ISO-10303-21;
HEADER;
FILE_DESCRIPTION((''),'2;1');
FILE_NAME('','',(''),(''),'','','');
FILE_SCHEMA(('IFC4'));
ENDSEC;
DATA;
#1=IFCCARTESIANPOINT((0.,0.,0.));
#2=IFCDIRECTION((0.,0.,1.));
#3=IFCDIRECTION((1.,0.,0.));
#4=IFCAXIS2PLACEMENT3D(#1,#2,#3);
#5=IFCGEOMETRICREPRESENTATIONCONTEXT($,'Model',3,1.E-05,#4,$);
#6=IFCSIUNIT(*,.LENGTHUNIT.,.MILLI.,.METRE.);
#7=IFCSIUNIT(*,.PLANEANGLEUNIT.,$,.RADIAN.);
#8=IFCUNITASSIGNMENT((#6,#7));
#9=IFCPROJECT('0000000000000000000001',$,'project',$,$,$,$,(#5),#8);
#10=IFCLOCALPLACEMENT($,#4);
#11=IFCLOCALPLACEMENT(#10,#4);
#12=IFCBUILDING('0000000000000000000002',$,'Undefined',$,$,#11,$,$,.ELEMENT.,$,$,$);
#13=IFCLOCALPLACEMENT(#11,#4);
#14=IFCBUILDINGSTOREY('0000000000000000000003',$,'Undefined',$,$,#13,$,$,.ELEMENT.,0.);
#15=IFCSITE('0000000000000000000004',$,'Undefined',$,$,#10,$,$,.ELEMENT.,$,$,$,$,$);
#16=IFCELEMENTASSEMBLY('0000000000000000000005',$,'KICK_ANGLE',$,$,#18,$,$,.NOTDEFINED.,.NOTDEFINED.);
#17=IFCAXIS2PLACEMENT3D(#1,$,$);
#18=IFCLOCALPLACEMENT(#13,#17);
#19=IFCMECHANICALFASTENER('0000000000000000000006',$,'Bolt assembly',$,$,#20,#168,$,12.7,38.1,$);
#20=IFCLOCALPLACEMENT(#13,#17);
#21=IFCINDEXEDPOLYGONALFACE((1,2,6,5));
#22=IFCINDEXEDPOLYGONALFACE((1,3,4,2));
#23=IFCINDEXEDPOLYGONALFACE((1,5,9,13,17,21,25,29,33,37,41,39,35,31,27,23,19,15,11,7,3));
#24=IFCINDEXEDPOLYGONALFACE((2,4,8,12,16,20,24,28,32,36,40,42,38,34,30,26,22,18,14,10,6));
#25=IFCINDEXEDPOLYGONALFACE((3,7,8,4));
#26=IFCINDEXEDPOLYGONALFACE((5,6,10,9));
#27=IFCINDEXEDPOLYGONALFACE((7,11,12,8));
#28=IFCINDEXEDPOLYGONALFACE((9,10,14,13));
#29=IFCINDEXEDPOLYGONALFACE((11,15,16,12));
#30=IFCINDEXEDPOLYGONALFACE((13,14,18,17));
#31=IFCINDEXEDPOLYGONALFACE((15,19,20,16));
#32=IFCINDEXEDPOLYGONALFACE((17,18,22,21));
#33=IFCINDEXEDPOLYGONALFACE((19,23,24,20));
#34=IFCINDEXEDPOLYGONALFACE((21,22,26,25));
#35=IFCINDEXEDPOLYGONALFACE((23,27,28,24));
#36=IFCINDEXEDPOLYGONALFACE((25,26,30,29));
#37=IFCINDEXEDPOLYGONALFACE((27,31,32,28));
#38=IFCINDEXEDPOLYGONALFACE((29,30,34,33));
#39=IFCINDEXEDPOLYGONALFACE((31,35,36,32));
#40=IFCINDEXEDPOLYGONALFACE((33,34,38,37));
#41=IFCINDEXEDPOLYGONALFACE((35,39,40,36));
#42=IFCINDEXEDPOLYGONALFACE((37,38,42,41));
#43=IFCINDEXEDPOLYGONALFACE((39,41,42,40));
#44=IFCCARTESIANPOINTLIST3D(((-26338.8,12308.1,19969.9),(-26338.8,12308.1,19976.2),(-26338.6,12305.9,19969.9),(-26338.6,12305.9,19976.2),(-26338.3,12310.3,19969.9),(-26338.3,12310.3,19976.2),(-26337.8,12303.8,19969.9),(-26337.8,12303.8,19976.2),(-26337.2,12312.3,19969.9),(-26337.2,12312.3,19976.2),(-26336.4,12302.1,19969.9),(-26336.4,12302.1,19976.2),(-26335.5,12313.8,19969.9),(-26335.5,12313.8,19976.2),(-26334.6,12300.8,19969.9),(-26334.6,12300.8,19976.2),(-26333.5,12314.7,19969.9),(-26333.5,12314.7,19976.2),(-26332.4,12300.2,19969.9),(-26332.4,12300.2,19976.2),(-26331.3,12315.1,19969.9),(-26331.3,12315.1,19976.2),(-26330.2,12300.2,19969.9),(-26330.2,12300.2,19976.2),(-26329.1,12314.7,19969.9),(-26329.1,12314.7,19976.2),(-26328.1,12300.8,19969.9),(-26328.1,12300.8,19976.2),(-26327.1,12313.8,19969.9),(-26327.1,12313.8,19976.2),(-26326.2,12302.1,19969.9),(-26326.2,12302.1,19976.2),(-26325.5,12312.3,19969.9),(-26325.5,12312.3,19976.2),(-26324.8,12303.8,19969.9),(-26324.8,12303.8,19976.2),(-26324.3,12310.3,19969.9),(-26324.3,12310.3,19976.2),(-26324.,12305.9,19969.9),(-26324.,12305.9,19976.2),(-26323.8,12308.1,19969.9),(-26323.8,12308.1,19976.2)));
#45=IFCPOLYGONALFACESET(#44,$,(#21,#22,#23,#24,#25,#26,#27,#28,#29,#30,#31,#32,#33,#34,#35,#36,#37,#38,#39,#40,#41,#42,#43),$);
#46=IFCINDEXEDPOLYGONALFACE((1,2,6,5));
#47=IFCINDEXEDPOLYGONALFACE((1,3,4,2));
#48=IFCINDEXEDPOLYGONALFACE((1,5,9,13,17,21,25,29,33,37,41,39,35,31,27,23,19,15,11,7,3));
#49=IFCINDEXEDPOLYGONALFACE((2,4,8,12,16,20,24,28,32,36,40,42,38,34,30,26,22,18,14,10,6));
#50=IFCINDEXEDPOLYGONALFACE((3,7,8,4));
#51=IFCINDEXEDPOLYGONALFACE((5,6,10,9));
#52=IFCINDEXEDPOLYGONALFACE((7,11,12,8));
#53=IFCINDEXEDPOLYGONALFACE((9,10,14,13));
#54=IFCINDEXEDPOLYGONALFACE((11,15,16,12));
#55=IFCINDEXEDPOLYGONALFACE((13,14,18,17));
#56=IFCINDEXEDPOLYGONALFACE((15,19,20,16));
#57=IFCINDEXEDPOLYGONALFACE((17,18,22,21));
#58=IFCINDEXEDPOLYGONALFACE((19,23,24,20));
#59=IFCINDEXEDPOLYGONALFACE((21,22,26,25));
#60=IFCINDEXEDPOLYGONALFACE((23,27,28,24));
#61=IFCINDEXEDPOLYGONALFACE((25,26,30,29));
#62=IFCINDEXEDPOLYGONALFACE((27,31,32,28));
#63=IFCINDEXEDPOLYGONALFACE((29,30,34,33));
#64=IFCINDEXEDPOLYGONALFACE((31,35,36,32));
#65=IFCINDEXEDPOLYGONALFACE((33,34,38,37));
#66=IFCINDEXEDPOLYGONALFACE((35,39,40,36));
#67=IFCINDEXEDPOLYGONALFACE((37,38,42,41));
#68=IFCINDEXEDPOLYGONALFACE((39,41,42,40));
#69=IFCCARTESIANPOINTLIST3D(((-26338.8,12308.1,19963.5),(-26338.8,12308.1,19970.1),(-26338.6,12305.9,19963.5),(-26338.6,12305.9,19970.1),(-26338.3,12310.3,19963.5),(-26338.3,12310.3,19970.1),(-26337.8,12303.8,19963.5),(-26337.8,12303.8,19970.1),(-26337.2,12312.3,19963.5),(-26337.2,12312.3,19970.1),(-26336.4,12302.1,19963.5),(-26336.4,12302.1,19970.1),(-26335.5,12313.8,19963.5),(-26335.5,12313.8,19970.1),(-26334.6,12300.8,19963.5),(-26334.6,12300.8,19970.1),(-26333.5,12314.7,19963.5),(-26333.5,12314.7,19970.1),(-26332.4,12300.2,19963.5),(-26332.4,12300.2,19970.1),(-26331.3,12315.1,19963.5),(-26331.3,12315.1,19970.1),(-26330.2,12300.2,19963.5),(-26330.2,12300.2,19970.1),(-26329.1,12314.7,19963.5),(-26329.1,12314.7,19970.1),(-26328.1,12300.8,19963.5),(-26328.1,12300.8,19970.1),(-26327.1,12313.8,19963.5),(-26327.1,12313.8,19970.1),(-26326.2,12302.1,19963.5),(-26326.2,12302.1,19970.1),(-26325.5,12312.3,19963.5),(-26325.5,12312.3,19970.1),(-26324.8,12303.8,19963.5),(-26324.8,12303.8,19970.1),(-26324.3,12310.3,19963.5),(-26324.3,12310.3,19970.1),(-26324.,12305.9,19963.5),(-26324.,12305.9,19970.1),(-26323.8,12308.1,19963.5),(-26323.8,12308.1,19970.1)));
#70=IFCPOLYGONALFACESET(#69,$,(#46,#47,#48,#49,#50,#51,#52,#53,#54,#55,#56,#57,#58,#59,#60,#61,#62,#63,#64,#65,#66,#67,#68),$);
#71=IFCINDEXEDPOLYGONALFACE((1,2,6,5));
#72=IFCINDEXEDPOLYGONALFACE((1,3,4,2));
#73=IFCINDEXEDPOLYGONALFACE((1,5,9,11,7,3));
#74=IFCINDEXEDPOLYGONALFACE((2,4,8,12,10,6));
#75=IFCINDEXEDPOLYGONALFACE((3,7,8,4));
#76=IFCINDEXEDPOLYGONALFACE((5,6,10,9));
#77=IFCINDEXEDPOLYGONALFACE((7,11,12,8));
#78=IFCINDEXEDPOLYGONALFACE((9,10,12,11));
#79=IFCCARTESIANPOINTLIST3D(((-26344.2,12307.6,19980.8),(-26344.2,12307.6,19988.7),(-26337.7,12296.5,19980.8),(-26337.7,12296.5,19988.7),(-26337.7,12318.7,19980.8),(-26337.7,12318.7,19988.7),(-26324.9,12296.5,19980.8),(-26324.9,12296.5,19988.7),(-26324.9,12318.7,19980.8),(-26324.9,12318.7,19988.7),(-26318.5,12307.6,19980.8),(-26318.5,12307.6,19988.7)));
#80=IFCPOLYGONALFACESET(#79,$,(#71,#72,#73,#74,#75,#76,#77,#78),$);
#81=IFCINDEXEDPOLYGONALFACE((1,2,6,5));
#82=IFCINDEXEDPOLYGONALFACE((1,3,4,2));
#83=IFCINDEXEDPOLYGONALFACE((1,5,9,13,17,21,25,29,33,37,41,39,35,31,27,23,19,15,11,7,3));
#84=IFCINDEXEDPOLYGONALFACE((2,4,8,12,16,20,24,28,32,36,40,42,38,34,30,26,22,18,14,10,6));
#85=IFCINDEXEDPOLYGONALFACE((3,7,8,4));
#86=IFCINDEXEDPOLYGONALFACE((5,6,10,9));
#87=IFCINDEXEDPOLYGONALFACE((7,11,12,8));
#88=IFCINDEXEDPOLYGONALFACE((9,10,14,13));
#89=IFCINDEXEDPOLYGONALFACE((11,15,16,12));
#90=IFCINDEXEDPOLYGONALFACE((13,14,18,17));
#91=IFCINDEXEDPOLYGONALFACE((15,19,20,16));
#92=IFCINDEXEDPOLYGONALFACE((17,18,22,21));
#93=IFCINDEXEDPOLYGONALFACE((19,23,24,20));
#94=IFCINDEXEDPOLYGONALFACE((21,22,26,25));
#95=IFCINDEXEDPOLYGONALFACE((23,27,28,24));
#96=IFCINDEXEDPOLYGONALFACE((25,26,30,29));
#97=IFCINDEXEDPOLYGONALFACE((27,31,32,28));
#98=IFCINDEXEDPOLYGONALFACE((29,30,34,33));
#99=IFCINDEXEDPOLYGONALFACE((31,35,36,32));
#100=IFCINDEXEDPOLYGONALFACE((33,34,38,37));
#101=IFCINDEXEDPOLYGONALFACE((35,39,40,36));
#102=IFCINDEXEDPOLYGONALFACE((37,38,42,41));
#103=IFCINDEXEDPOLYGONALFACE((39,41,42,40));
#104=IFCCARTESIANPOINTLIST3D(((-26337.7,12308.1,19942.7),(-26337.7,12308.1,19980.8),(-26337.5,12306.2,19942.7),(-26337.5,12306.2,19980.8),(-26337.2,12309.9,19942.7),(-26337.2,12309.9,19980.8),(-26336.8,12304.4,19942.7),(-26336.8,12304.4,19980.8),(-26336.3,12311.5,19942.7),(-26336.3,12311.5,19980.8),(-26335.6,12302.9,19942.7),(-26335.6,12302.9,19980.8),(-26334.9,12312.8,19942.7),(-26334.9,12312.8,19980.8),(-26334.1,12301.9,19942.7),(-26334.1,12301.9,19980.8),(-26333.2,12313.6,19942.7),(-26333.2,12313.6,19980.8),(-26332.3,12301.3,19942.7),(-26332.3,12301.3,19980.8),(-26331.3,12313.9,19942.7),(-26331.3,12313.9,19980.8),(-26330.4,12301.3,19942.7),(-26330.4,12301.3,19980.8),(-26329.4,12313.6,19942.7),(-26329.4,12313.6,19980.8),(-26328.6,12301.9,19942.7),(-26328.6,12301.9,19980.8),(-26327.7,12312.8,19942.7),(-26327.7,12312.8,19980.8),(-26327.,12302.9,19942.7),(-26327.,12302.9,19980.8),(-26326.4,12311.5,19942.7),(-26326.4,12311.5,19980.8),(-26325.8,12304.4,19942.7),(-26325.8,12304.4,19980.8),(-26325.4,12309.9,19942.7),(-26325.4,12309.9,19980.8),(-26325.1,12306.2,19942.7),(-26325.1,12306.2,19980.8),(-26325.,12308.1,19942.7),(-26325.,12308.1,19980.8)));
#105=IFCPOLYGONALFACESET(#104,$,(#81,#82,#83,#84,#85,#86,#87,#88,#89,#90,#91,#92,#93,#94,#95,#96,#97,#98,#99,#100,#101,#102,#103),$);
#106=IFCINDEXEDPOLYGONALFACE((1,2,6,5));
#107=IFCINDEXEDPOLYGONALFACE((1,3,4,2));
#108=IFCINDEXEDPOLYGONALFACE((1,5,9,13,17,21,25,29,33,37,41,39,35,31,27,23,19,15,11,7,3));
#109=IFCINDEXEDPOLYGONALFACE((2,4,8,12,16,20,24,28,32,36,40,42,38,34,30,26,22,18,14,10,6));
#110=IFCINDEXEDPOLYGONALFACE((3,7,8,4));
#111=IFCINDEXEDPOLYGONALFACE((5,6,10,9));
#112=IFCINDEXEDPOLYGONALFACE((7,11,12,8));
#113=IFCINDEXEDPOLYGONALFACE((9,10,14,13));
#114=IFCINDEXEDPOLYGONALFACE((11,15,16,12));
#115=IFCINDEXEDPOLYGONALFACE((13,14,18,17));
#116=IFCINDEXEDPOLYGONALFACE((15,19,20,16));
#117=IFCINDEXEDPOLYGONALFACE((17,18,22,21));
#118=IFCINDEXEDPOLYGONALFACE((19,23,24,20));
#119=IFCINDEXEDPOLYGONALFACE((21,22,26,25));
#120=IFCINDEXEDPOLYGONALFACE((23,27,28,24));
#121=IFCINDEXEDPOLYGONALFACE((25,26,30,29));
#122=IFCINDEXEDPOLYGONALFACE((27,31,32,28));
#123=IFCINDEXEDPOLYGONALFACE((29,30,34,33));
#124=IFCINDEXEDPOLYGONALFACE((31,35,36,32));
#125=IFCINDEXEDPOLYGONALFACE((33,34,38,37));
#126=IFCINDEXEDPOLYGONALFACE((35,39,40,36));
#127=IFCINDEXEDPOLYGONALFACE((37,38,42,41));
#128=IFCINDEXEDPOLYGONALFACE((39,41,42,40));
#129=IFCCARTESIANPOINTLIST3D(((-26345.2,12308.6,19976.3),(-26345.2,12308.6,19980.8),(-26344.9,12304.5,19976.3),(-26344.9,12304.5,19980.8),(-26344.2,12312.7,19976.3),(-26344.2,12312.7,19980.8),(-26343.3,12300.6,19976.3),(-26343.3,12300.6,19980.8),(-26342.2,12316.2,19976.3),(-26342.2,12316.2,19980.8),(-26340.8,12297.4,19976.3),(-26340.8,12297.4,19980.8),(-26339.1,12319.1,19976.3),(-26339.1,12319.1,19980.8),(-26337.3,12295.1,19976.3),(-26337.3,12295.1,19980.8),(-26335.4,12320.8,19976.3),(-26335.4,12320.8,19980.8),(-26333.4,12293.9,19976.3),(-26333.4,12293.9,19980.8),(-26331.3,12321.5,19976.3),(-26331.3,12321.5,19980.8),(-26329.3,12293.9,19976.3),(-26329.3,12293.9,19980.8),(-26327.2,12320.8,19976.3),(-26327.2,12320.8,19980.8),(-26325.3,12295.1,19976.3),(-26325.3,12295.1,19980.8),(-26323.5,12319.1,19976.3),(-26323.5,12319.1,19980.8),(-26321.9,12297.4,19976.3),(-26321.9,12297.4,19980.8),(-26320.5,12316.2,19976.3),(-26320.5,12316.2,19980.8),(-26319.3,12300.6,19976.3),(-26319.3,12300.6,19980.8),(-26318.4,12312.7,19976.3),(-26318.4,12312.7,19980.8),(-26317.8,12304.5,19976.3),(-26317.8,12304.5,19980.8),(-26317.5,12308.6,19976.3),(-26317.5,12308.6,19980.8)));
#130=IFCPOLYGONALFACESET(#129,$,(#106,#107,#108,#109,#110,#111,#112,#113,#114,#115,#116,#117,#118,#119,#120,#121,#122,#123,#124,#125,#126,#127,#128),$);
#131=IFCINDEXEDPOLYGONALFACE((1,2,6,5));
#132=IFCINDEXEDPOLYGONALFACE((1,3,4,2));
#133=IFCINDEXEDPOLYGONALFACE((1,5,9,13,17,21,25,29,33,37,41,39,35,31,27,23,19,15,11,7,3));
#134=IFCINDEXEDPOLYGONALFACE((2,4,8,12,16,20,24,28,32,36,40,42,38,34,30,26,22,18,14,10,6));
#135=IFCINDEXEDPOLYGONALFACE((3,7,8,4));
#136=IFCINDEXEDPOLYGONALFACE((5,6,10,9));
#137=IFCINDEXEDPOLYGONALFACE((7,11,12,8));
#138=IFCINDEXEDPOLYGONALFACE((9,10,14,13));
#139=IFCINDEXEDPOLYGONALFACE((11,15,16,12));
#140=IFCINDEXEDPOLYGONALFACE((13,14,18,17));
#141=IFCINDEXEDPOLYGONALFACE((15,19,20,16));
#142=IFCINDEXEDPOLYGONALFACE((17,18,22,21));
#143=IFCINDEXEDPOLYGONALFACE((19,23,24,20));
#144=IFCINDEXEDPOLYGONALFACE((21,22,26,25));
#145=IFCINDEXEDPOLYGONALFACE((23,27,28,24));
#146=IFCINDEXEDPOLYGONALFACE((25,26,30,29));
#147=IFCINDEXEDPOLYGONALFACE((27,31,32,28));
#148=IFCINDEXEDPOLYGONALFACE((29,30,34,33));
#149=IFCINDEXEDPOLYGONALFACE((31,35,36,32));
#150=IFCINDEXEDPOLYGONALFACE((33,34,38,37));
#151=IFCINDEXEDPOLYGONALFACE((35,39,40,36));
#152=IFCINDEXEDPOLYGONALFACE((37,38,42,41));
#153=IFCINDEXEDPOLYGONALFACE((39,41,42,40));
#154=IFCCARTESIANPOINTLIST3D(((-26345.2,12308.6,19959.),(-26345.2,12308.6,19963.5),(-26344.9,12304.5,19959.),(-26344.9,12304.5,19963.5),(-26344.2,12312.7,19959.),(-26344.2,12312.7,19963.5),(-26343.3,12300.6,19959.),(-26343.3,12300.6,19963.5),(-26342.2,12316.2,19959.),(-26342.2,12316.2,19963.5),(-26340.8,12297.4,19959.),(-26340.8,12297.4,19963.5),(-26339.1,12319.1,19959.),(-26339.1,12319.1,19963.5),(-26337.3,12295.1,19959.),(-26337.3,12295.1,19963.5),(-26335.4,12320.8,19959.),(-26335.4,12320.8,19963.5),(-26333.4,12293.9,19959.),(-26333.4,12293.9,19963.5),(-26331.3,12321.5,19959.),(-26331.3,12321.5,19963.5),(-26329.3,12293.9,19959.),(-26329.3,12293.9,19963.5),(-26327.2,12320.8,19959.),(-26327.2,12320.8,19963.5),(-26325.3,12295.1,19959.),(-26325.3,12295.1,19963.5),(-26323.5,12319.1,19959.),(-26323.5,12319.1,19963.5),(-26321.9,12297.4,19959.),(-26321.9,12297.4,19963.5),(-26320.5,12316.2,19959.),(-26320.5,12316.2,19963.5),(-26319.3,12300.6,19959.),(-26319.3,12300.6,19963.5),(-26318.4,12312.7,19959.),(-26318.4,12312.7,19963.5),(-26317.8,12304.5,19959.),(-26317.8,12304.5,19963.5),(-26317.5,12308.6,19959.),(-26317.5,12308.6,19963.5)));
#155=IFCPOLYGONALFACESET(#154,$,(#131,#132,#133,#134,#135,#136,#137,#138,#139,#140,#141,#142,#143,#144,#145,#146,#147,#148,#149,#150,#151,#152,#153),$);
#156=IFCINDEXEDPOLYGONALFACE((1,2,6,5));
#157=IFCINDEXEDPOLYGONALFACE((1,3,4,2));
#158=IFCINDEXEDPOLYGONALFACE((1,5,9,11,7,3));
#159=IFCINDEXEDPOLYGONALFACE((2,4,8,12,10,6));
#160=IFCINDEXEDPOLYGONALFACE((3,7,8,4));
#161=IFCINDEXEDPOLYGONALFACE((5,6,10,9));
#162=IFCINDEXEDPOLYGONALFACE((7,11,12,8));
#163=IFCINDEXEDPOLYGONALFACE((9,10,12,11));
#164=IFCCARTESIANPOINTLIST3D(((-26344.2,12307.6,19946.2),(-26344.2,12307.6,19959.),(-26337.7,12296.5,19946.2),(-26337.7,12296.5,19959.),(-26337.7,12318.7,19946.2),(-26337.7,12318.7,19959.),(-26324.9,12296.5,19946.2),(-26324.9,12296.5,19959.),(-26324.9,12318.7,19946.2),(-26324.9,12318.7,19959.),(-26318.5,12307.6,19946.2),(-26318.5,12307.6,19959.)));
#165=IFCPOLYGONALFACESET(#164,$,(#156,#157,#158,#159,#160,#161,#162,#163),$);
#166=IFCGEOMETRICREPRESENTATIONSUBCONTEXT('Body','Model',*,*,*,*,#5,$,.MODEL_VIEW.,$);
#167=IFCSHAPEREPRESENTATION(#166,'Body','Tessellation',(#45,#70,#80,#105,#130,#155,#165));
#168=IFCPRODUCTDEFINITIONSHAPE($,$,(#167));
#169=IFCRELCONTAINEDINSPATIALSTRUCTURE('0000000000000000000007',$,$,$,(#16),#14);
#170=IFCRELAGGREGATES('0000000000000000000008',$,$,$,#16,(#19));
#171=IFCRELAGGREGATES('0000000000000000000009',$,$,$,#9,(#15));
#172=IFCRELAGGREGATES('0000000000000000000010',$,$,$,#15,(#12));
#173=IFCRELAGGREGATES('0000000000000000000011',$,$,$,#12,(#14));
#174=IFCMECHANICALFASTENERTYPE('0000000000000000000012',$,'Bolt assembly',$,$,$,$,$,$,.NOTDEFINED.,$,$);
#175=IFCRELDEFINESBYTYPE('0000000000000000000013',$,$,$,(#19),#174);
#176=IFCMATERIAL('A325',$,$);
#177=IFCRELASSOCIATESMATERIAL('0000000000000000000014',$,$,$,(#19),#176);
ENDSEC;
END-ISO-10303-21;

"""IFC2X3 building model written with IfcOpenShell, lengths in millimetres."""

from ifc_helpers import new_model, si_unit, frame, origin_with_axes, origin_2d_with_axis, place, context, subcontext, project, spatial, polyline, circle, outline, extrude, source, transform, mapped, material, type_object, element, aggregate, save


model = new_model("IFC2X3")

# Units and contexts
model_context = context("Model", 3, precision=1e-05, world=origin_with_axes())
body_context = subcontext(model_context, "Body", "Model", "MODEL_VIEW")
ifc_project = project(units=[si_unit("LENGTHUNIT", "METRE", prefix="MILLI"), si_unit("PLANEANGLEUNIT", "RADIAN")], contexts=[model_context])

# Site, building, storey
site_placement = place(None, origin_with_axes())
site = spatial("IfcSite", under=ifc_project, at=site_placement, Name="Undefined", CompositionType="ELEMENT")
building_placement = place(site_placement, origin_with_axes())
building = spatial("IfcBuilding", under=site, at=building_placement, Name="Undefined", CompositionType="ELEMENT")
storey_placement = place(building_placement, origin_with_axes())
storey = spatial("IfcBuildingStorey", under=building, at=storey_placement, Name="Undefined", CompositionType="ELEMENT", Elevation=0.0)

# Shared definitions
ifc_material_1 = material(Name="A325")
mechanical_fastener_type = type_object("IfcMechanicalFastenerType", Name="Bolt assembly")

# Element assembly, mechanical fastener
assembly_1_placement = place(storey_placement, origin_with_axes())
assembly_1 = element("IfcElementAssembly", 1, at=assembly_1_placement, inside=storey, Name="KICK_ANGLE", AssemblyPlace="NOTDEFINED", PredefinedType="NOTDEFINED")
shared_shape_1 = source(origin_with_axes(), body_context, "Body", "SweptSolid", [
    extrude(circle(Radius=7.5, at=origin_2d_with_axis()), frame((0.0, -6.2, 0.0), z_axis=(0.0, 1.0, 0.0), x_axis=(1.0, 0.0, 0.0)), (0.0, 0.0, 1.0), 6.3),
    extrude(circle(Radius=7.5, at=origin_2d_with_axis()), frame((0.0, -0.1, 0.0), z_axis=(0.0, 1.0, 0.0), x_axis=(1.0, 0.0, 0.0)), (0.0, 0.0, 1.0), 6.6),
    extrude(outline(polyline([(11.1, -6.4), (11.1, 6.4), (0.0, 12.8), (-11.1, 6.4), (-11.1, -6.4), (0.0, -12.8), (11.1, -6.4)])), frame((0.0, -18.7, 0.0), z_axis=(0.0, 1.0, 0.0), x_axis=(1.0, 0.0, 0.0)), (0.0, 0.0, 1.0), 7.9),
    extrude(circle(Radius=6.3, at=origin_2d_with_axis()), frame((0.0, -10.8, 0.0), z_axis=(0.0, 1.0, 0.0), x_axis=(1.0, 0.0, 0.0)), (0.0, 0.0, 1.0), 38.1),
    extrude(circle(Radius=13.9, at=origin_2d_with_axis()), frame((0.0, -10.8, 0.0), z_axis=(0.0, 1.0, 0.0), x_axis=(1.0, 0.0, 0.0)), (0.0, 0.0, 1.0), 4.5),
    extrude(circle(Radius=13.9, at=origin_2d_with_axis()), frame((0.0, 6.5, 0.0), z_axis=(0.0, 1.0, 0.0), x_axis=(1.0, 0.0, 0.0)), (0.0, 0.0, 1.0), 4.5),
    extrude(outline(polyline([(11.1, -6.4), (11.1, 6.4), (0.0, 12.8), (-11.1, 6.4), (-11.1, -6.4), (0.0, -12.8), (11.1, -6.4)])), frame((0.0, 11.0, 0.0), z_axis=(0.0, 1.0, 0.0), x_axis=(1.0, 0.0, 0.0)), (0.0, 0.0, 1.0), 12.8),
])
mechanical_fastener_1_placement = place(assembly_1_placement, frame((-26331.3, 12280.1, 19970.0), z_axis=(-1.0, 0.0, 0.0), x_axis=(0.0, 1.0, 0.0)))
mechanical_fastener_1 = element("IfcMechanicalFastener", 2, at=mechanical_fastener_1_placement, type_object=mechanical_fastener_type, material=ifc_material_1, Name="Bolt assembly", NominalDiameter=12.7, NominalLength=38.1, context=body_context, shape_type="MappedRepresentation", body=[
    mapped(shared_shape_1, transform((27.5, 0.0, 0.0))),
])
aggregate(assembly_1, [mechanical_fastener_1])

save(model, "model.ifc")
